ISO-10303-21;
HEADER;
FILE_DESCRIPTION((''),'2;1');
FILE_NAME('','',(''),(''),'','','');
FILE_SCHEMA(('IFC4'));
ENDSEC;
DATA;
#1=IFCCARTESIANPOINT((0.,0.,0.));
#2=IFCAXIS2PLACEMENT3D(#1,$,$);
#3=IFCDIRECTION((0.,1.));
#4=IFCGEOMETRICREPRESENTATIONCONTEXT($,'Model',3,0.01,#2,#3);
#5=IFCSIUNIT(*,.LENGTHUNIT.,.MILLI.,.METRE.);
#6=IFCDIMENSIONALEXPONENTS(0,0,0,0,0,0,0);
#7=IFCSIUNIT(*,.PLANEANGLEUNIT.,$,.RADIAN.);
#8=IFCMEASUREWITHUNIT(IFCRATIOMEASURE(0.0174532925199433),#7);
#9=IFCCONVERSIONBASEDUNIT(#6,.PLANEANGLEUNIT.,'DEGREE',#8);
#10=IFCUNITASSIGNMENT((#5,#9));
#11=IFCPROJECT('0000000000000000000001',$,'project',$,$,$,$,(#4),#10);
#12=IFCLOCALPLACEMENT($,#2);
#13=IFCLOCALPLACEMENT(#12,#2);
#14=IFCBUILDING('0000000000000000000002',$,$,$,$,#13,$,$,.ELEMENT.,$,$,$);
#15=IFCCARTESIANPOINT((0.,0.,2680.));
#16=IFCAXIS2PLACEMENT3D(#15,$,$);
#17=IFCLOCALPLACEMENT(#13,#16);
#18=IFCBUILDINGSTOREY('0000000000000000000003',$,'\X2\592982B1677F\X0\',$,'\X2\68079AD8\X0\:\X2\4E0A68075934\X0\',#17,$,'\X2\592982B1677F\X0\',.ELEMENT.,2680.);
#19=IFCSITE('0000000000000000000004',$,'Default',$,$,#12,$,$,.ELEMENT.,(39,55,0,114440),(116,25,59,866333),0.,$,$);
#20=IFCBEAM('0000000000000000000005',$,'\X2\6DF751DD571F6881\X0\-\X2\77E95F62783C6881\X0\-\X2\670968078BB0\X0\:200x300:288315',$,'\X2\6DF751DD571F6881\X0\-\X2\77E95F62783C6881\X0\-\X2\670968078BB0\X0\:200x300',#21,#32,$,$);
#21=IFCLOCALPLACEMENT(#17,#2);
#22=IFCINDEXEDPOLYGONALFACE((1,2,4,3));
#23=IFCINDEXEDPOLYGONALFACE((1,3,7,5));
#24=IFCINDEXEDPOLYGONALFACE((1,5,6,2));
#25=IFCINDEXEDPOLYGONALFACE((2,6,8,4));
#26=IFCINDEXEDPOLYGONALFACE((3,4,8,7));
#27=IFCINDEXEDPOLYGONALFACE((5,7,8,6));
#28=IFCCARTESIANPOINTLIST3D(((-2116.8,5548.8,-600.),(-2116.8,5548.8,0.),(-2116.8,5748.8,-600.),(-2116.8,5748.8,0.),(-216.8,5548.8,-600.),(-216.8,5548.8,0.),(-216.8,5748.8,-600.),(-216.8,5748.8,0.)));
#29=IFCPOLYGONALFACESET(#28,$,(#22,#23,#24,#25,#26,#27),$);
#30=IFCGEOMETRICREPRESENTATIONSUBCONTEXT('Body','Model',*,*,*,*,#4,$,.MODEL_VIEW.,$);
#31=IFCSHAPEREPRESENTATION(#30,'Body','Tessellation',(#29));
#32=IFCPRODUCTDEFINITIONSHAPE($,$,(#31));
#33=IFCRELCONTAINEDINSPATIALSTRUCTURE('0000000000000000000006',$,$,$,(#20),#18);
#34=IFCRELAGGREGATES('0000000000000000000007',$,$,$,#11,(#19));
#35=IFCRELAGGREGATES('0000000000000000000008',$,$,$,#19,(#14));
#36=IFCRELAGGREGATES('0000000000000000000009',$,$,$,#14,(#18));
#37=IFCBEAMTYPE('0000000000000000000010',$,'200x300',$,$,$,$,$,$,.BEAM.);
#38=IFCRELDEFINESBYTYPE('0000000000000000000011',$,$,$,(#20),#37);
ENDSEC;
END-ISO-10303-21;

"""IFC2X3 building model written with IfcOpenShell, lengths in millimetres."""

from ifc_helpers import new_model, entity, si_unit, converted_unit, direction, frame, frame_2d, origin, place, context, subcontext, project, spatial, rectangle, extrude, type_object, element, save


model = new_model("IFC2X3")

# Units and contexts
model_context = context("Model", 3, precision=0.01, world=origin(), true_north=direction((0.0, 1.0)))
body_context = subcontext(model_context, "Body", "Model", "MODEL_VIEW")
ifc_project = project(units=[si_unit("LENGTHUNIT", "METRE", prefix="MILLI"), converted_unit("PLANEANGLEUNIT", "DEGREE", entity("IfcRatioMeasure", 0.0174532925199433), si_unit("PLANEANGLEUNIT", "RADIAN"), dimensions=[0, 0, 0, 0, 0, 0, 0])], contexts=[model_context])

# Site, building, storey
site_placement = place(None, origin())
site = spatial("IfcSite", under=ifc_project, at=site_placement, Name="Default", CompositionType="ELEMENT", RefLatitude=(39, 55, 0, 114440), RefLongitude=(116, 25, 59, 866333), RefElevation=0.0)
building_placement = place(site_placement, origin())
building = spatial("IfcBuilding", under=site, at=building_placement, CompositionType="ELEMENT")
storey_placement = place(building_placement, frame((0.0, 0.0, 2680.0)))
storey = spatial("IfcBuildingStorey", under=building, at=storey_placement, Name="天花板", ObjectType="标高:上标头", LongName="天花板", CompositionType="ELEMENT", Elevation=2680.0)

# Beam
beam_type = type_object("IfcBeamType", Name="200x300", PredefinedType="BEAM")
beam_placement = place(storey_placement, frame((-2116.8, 5648.8, 0.0)))
element("IfcBeam", 1, at=beam_placement, inside=storey, type_object=beam_type, Name="混凝土梁-矩形砼梁-有标记:200x300:288315", ObjectType="混凝土梁-矩形砼梁-有标记:200x300", context=body_context, shape_type="SweptSolid", body=[
    extrude(rectangle(XDim=600.0, YDim=200.0, at=frame_2d((0.0, 0.0), x_axis=(1.0, 0.0))), frame((0.0, 0.0, -300.0), z_axis=(1.0, 0.0, 0.0), x_axis=(0.0, 0.0, -1.0)), (0.0, 0.0, 1.0), 1900.0),
])

save(model, "model.ifc")
